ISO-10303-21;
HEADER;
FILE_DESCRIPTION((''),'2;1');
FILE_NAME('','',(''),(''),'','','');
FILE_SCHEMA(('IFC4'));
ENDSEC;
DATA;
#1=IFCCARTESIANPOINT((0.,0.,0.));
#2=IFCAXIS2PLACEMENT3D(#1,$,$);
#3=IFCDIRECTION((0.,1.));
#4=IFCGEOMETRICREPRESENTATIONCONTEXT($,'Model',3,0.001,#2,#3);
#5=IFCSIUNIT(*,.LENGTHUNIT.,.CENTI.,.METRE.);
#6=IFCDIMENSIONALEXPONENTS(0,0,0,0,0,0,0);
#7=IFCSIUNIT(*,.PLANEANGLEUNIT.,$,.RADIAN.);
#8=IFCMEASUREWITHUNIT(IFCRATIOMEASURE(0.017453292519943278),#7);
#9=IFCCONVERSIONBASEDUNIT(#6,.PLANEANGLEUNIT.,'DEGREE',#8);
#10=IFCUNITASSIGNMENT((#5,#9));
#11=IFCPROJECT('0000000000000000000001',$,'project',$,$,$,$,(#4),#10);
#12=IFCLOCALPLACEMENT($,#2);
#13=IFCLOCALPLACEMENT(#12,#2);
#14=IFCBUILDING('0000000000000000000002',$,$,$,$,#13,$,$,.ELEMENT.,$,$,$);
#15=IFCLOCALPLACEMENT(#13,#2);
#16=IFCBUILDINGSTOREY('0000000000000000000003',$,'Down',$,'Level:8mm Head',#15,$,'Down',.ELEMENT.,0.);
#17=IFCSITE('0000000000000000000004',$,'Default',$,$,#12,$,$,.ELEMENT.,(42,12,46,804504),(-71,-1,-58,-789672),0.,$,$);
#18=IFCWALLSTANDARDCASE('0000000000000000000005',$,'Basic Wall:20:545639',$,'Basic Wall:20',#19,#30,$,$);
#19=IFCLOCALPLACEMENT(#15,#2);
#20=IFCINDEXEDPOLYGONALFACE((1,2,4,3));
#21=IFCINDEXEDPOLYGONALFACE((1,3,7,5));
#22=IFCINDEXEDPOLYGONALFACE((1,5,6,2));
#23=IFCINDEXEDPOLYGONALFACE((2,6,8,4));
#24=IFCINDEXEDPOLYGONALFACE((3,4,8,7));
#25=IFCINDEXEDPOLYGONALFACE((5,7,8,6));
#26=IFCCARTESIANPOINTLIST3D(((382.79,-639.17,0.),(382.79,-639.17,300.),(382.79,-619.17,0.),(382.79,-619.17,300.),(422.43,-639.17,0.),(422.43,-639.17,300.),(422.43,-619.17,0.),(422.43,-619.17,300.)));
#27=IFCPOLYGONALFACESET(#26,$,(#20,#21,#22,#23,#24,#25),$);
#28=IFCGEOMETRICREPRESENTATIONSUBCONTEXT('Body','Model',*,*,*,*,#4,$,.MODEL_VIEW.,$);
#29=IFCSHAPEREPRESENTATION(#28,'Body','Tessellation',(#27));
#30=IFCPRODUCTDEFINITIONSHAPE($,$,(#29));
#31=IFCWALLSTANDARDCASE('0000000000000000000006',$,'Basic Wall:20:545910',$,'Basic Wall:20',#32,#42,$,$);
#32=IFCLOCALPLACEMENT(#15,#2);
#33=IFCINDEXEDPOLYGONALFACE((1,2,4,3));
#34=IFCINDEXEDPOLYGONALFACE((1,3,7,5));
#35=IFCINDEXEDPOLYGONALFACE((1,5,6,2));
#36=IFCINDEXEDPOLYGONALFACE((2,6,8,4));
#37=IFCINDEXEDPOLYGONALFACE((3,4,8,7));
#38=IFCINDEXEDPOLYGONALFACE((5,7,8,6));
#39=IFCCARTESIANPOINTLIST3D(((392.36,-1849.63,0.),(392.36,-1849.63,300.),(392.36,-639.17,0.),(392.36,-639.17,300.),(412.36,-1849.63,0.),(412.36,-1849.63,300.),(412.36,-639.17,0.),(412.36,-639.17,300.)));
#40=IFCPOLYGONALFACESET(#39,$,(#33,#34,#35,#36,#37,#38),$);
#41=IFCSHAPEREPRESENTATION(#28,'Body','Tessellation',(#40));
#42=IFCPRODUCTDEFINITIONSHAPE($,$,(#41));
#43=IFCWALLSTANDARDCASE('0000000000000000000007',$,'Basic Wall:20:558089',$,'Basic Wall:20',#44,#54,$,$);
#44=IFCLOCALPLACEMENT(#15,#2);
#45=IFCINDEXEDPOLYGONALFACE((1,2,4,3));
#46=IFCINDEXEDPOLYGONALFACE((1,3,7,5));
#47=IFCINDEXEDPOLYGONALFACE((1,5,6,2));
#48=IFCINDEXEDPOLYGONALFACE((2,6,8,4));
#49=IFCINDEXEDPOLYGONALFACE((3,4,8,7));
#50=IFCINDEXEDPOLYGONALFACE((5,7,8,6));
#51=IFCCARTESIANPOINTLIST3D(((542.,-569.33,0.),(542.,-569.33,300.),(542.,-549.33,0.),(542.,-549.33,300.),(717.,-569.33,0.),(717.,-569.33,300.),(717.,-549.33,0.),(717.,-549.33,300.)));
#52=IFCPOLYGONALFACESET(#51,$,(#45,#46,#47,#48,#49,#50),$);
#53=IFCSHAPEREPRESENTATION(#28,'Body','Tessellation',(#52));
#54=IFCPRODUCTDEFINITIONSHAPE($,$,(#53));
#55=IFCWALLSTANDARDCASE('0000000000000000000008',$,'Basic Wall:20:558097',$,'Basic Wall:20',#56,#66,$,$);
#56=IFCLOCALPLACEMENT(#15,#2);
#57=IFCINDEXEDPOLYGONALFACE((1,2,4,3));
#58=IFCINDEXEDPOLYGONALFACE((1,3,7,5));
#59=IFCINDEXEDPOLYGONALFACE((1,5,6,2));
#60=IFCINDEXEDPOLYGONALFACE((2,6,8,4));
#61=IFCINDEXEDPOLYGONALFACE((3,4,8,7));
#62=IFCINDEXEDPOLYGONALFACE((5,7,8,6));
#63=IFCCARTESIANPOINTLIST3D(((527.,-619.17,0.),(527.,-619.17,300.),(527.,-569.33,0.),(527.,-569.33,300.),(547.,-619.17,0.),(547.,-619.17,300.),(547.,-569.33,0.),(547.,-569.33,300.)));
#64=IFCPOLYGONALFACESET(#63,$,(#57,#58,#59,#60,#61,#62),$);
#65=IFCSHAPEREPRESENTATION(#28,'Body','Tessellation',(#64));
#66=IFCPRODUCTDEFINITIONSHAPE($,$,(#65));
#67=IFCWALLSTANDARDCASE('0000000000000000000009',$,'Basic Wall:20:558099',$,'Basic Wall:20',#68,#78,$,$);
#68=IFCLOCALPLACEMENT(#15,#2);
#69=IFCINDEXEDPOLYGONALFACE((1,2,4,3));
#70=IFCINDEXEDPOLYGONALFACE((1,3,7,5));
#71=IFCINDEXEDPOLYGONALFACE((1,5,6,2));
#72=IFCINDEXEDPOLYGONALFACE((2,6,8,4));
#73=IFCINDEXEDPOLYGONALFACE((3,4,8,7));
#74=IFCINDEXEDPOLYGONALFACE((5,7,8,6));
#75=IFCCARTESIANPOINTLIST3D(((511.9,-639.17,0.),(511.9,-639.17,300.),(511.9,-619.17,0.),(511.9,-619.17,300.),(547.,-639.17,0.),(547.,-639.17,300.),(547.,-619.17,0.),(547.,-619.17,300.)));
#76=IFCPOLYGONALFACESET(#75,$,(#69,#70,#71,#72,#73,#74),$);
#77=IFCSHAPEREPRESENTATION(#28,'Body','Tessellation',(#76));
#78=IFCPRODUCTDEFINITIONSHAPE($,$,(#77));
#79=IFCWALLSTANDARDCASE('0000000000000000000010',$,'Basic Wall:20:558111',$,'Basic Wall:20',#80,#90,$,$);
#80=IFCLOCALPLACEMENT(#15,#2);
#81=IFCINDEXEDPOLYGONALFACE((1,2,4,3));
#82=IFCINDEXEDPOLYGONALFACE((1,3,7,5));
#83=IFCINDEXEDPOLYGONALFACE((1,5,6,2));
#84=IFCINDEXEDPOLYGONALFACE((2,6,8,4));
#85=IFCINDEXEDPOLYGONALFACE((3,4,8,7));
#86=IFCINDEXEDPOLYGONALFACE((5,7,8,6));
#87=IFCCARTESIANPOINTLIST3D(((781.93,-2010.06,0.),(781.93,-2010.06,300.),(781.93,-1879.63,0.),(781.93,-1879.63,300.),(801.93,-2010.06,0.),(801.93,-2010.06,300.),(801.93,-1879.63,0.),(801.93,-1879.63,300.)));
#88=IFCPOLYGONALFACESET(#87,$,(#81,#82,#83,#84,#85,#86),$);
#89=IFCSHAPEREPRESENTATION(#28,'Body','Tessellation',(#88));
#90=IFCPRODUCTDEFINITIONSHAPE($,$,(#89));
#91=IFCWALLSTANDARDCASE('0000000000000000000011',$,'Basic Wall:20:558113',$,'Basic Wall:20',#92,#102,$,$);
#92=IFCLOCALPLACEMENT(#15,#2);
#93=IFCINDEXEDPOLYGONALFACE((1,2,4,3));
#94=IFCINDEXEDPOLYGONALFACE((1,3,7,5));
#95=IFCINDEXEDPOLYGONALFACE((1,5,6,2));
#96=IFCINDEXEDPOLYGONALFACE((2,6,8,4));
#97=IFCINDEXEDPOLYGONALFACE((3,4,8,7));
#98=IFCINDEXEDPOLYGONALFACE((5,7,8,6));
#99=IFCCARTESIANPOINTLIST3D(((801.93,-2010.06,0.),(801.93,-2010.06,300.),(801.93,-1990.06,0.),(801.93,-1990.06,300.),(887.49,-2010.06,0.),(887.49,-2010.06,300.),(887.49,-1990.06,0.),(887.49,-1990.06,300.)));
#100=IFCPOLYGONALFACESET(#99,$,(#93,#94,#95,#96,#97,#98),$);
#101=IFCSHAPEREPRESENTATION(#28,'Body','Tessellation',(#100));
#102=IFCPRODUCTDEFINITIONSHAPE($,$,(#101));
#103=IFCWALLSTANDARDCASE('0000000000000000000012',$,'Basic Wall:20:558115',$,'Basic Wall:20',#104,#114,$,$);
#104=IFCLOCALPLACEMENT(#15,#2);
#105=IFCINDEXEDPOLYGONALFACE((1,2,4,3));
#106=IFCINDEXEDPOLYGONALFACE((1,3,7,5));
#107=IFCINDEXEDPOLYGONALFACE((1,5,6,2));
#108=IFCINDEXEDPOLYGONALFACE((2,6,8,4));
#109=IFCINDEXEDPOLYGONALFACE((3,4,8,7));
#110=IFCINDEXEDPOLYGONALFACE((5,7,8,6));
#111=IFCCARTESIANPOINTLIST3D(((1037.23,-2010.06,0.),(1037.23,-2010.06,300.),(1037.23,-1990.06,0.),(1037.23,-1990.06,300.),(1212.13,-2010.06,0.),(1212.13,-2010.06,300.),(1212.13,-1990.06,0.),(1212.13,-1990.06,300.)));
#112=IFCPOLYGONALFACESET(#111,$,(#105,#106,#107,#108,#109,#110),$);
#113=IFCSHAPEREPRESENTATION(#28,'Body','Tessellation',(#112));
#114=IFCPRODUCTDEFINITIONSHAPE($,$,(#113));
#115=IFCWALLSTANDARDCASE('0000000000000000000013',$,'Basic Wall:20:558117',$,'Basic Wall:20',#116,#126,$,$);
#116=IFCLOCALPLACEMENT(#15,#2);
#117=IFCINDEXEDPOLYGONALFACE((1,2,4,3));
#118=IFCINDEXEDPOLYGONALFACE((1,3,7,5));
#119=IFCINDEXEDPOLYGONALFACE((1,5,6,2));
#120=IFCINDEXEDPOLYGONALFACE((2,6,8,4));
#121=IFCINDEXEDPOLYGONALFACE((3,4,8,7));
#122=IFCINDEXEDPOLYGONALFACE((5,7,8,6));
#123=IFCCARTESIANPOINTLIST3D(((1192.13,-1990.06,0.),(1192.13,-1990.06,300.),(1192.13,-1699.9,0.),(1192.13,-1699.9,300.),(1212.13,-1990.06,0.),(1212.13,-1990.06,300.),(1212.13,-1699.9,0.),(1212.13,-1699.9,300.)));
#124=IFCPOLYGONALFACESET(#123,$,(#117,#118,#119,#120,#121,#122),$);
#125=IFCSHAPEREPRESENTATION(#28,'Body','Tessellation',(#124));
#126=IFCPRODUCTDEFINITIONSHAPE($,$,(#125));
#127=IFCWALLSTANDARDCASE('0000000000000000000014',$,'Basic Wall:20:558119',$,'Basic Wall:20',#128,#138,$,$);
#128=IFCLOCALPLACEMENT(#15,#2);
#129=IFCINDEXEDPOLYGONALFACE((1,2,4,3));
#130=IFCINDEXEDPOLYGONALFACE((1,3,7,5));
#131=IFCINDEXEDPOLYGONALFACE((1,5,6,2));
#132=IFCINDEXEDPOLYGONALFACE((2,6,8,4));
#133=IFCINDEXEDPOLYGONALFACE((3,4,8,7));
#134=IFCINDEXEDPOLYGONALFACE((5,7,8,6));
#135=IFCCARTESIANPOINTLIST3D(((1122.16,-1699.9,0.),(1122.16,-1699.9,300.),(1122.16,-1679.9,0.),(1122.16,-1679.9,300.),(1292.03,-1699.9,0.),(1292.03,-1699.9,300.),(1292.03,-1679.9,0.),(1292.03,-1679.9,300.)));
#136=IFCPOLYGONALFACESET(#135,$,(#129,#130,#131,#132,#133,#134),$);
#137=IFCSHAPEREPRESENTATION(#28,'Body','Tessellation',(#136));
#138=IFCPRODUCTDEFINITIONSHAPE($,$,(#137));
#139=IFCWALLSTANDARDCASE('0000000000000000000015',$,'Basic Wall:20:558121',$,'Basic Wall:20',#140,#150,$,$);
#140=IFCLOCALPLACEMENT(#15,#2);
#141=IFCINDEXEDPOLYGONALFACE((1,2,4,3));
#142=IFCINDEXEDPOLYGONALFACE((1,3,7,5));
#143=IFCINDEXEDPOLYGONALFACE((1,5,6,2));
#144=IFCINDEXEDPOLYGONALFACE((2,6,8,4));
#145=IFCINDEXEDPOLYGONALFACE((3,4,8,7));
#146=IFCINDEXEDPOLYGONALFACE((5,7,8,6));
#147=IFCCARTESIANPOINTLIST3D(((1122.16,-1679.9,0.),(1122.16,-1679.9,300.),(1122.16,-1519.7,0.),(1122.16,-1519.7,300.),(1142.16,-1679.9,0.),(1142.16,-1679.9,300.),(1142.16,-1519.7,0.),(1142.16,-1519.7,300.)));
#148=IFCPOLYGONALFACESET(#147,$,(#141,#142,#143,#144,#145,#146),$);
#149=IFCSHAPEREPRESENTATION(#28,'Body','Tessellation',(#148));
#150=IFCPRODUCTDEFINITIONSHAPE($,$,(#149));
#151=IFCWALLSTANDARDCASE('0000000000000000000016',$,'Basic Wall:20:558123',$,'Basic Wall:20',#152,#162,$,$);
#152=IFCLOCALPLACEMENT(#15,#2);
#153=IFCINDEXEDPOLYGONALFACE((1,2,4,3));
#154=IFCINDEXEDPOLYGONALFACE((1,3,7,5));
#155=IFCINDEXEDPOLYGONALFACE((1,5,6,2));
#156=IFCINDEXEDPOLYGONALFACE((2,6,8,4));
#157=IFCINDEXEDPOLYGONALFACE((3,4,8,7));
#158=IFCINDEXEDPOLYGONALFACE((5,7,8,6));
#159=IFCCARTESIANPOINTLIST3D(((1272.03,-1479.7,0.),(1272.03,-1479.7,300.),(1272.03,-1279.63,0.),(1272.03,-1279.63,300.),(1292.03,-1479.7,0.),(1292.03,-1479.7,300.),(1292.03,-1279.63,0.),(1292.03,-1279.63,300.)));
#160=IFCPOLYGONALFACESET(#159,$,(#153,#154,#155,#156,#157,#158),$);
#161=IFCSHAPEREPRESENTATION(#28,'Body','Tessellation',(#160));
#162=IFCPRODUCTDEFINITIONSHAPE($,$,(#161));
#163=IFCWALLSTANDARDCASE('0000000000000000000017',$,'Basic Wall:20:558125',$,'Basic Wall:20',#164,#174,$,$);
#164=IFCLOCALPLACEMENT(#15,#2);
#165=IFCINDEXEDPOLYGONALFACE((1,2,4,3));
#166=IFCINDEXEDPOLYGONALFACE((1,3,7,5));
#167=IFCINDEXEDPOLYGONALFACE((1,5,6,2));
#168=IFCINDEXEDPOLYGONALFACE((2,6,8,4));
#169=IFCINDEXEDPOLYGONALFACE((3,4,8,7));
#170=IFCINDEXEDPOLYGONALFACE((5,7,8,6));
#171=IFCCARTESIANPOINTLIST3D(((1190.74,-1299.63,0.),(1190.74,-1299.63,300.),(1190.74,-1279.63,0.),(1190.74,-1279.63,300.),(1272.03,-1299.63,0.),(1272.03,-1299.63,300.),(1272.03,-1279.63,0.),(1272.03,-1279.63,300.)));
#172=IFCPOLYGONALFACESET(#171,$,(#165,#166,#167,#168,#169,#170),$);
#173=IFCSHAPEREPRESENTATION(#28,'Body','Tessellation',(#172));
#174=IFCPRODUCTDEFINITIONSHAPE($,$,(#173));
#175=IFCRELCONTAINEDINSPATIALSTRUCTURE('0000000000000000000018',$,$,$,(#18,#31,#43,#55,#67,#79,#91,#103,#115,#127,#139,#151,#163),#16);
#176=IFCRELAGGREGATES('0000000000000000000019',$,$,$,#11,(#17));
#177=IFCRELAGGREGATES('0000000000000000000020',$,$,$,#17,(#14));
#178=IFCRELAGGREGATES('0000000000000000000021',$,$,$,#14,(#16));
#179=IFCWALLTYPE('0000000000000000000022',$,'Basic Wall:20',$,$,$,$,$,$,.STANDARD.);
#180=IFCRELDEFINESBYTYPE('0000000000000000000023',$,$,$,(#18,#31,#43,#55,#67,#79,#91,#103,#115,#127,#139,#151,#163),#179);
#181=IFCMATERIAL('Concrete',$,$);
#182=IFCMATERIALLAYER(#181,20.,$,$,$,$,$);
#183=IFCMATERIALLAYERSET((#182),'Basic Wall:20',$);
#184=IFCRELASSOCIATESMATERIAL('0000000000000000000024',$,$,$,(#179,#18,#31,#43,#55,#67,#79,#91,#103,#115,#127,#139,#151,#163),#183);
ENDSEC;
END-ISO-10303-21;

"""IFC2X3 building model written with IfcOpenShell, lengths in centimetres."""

from ifc_helpers import new_model, entity, si_unit, converted_unit, direction, frame, frame_2d, origin, place, context, subcontext, project, spatial, rectangle, extrude, material, layer, layer_set, layer_usage, type_object, element, save


model = new_model("IFC2X3")

# Units and contexts
model_context = context("Model", 3, precision=0.001, world=origin(), true_north=direction((0.0, 1.0)))
body_context = subcontext(model_context, "Body", "Model", "MODEL_VIEW")
ifc_project = project(units=[si_unit("LENGTHUNIT", "METRE", prefix="CENTI"), converted_unit("PLANEANGLEUNIT", "DEGREE", entity("IfcRatioMeasure", 0.017453292519943278), si_unit("PLANEANGLEUNIT", "RADIAN"), dimensions=[0, 0, 0, 0, 0, 0, 0])], contexts=[model_context])

# Site, building, storey
site_placement = place(None, origin())
site = spatial("IfcSite", under=ifc_project, at=site_placement, Name="Default", CompositionType="ELEMENT", RefLatitude=(42, 12, 46, 804504), RefLongitude=(-71, -1, -58, -789672), RefElevation=0.0)
building_placement = place(site_placement, origin())
building = spatial("IfcBuilding", under=site, at=building_placement, CompositionType="ELEMENT")
storey_placement = place(building_placement, origin())
storey = spatial("IfcBuildingStorey", under=building, at=storey_placement, Name="Down", ObjectType="Level:8mm Head", LongName="Down", CompositionType="ELEMENT", Elevation=0.0)

# Walls
ifc_material = material(Name="Concrete")
ifc_layer_1 = layer(ifc_material, 20.0)
ifc_layer_set_1 = layer_set([ifc_layer_1], Name="Basic Wall:20")
ifc_layer_usage_1 = layer_usage(ifc_layer_set_1, "AXIS2", "POSITIVE", -10.0)
wall_type_1 = type_object("IfcWallType", Name="Basic Wall:20", PredefinedType="STANDARD", material=ifc_layer_set_1)
wall_1_placement = place(storey_placement, frame((382.79, -629.17, 0.0)))
element("IfcWallStandardCase", 1, at=wall_1_placement, inside=storey, type_object=wall_type_1, material=ifc_layer_usage_1, Name="Basic Wall:20:545639", ObjectType="Basic Wall:20", context=body_context, shape_type="SweptSolid", body=[
    extrude(rectangle(XDim=39.64, YDim=20.0, at=frame_2d((19.82, 0.0), x_axis=(-1.0, 0.0))), origin(), (0.0, 0.0, 1.0), 300.0),
])
ifc_layer_usage_2 = layer_usage(ifc_layer_set_1, "AXIS2", "NEGATIVE", 10.0)
wall_2_placement = place(storey_placement, frame((402.36, -639.17, 0.0), z_axis=(0.0, 0.0, 1.0), x_axis=(0.0, -1.0, 0.0)))
element("IfcWallStandardCase", 2, at=wall_2_placement, inside=storey, type_object=wall_type_1, material=ifc_layer_usage_2, Name="Basic Wall:20:545910", ObjectType="Basic Wall:20", context=body_context, shape_type="SweptSolid", body=[
    extrude(rectangle(XDim=1210.46, YDim=20.0, at=frame_2d((605.23, 0.0), x_axis=(-1.0, 0.0))), origin(), (0.0, 0.0, 1.0), 300.0),
])
ifc_layer_usage_3 = layer_usage(ifc_layer_set_1, "AXIS2", "NEGATIVE", 10.0)
wall_3_placement = place(storey_placement, frame((717.0, -559.33, 0.0), z_axis=(0.0, 0.0, 1.0), x_axis=(-1.0, 0.0, 0.0)))
element("IfcWallStandardCase", 3, at=wall_3_placement, inside=storey, type_object=wall_type_1, material=ifc_layer_usage_3, Name="Basic Wall:20:558089", ObjectType="Basic Wall:20", context=body_context, shape_type="SweptSolid", body=[
    extrude(rectangle(XDim=175.0, YDim=20.0, at=frame_2d((87.5, 0.0), x_axis=(-1.0, 0.0))), origin(), (0.0, 0.0, 1.0), 300.0),
])
ifc_layer_usage_4 = layer_usage(ifc_layer_set_1, "AXIS2", "POSITIVE", -10.0)
wall_4_placement = place(storey_placement, frame((537.0, -569.33, 0.0), z_axis=(0.0, 0.0, 1.0), x_axis=(0.0, -1.0, 0.0)))
element("IfcWallStandardCase", 4, at=wall_4_placement, inside=storey, type_object=wall_type_1, material=ifc_layer_usage_4, Name="Basic Wall:20:558097", ObjectType="Basic Wall:20", context=body_context, shape_type="SweptSolid", body=[
    extrude(rectangle(XDim=49.83, YDim=20.0, at=frame_2d((24.92, 0.0), x_axis=(-1.0, 0.0))), origin(), (0.0, 0.0, 1.0), 300.0),
])
ifc_layer_usage_5 = layer_usage(ifc_layer_set_1, "AXIS2", "NEGATIVE", 10.0)
wall_5_placement = place(storey_placement, frame((547.0, -629.17, 0.0), z_axis=(0.0, 0.0, 1.0), x_axis=(-1.0, 0.0, 0.0)))
element("IfcWallStandardCase", 5, at=wall_5_placement, inside=storey, type_object=wall_type_1, material=ifc_layer_usage_5, Name="Basic Wall:20:558099", ObjectType="Basic Wall:20", context=body_context, shape_type="SweptSolid", body=[
    extrude(rectangle(XDim=35.1, YDim=20.0, at=frame_2d((17.55, 0.0), x_axis=(-1.0, 0.0))), origin(), (0.0, 0.0, 1.0), 300.0),
])
ifc_layer_usage_6 = layer_usage(ifc_layer_set_1, "AXIS2", "NEGATIVE", 10.0)
wall_6_placement = place(storey_placement, frame((791.93, -1879.63, 0.0), z_axis=(0.0, 0.0, 1.0), x_axis=(0.0, -1.0, 0.0)))
element("IfcWallStandardCase", 6, at=wall_6_placement, inside=storey, type_object=wall_type_1, material=ifc_layer_usage_6, Name="Basic Wall:20:558111", ObjectType="Basic Wall:20", context=body_context, shape_type="SweptSolid", body=[
    extrude(rectangle(XDim=130.43, YDim=20.0, at=frame_2d((65.22, 0.0), x_axis=(-1.0, 0.0))), origin(), (0.0, 0.0, 1.0), 300.0),
])
ifc_layer_usage_7 = layer_usage(ifc_layer_set_1, "AXIS2", "POSITIVE", -10.0)
wall_7_placement = place(storey_placement, frame((801.93, -2000.06, 0.0)))
element("IfcWallStandardCase", 7, at=wall_7_placement, inside=storey, type_object=wall_type_1, material=ifc_layer_usage_7, Name="Basic Wall:20:558113", ObjectType="Basic Wall:20", context=body_context, shape_type="SweptSolid", body=[
    extrude(rectangle(XDim=85.56, YDim=20.0, at=frame_2d((42.78, 0.0), x_axis=(-1.0, 0.0))), origin(), (0.0, 0.0, 1.0), 300.0),
])
ifc_layer_usage_8 = layer_usage(ifc_layer_set_1, "AXIS2", "POSITIVE", -10.0)
wall_8_placement = place(storey_placement, frame((1037.23, -2000.06, 0.0)))
element("IfcWallStandardCase", 8, at=wall_8_placement, inside=storey, type_object=wall_type_1, material=ifc_layer_usage_8, Name="Basic Wall:20:558115", ObjectType="Basic Wall:20", context=body_context, shape_type="SweptSolid", body=[
    extrude(rectangle(XDim=174.9, YDim=20.0, at=frame_2d((87.45, 0.0), x_axis=(-1.0, 0.0))), origin(), (0.0, 0.0, 1.0), 300.0),
])
ifc_layer_usage_9 = layer_usage(ifc_layer_set_1, "AXIS2", "POSITIVE", -10.0)
wall_9_placement = place(storey_placement, frame((1202.13, -1990.06, 0.0), z_axis=(0.0, 0.0, 1.0), x_axis=(0.0, 1.0, 0.0)))
element("IfcWallStandardCase", 9, at=wall_9_placement, inside=storey, type_object=wall_type_1, material=ifc_layer_usage_9, Name="Basic Wall:20:558117", ObjectType="Basic Wall:20", context=body_context, shape_type="SweptSolid", body=[
    extrude(rectangle(XDim=290.17, YDim=20.0, at=frame_2d((145.08, 0.0), x_axis=(-1.0, 0.0))), origin(), (0.0, 0.0, 1.0), 300.0),
])
ifc_layer_usage_10 = layer_usage(ifc_layer_set_1, "AXIS2", "NEGATIVE", 10.0)
wall_10_placement = place(storey_placement, frame((1292.03, -1689.9, 0.0), z_axis=(0.0, 0.0, 1.0), x_axis=(-1.0, 0.0, 0.0)))
element("IfcWallStandardCase", 10, at=wall_10_placement, inside=storey, type_object=wall_type_1, material=ifc_layer_usage_10, Name="Basic Wall:20:558119", ObjectType="Basic Wall:20", context=body_context, shape_type="SweptSolid", body=[
    extrude(rectangle(XDim=169.87, YDim=20.0, at=frame_2d((84.93, 0.0), x_axis=(-1.0, 0.0))), origin(), (0.0, 0.0, 1.0), 300.0),
])
ifc_layer_usage_11 = layer_usage(ifc_layer_set_1, "AXIS2", "NEGATIVE", 10.0)
wall_11_placement = place(storey_placement, frame((1132.16, -1679.9, 0.0), z_axis=(0.0, 0.0, 1.0), x_axis=(0.0, 1.0, 0.0)))
element("IfcWallStandardCase", 11, at=wall_11_placement, inside=storey, type_object=wall_type_1, material=ifc_layer_usage_11, Name="Basic Wall:20:558121", ObjectType="Basic Wall:20", context=body_context, shape_type="SweptSolid", body=[
    extrude(rectangle(XDim=160.2, YDim=20.0, at=frame_2d((80.1, 0.0), x_axis=(-1.0, 0.0))), origin(), (0.0, 0.0, 1.0), 300.0),
])
ifc_layer_usage_12 = layer_usage(ifc_layer_set_1, "AXIS2", "POSITIVE", -10.0)
wall_12_placement = place(storey_placement, frame((1282.03, -1479.7, 0.0), z_axis=(0.0, 0.0, 1.0), x_axis=(0.0, 1.0, 0.0)))
element("IfcWallStandardCase", 12, at=wall_12_placement, inside=storey, type_object=wall_type_1, material=ifc_layer_usage_12, Name="Basic Wall:20:558123", ObjectType="Basic Wall:20", context=body_context, shape_type="SweptSolid", body=[
    extrude(rectangle(XDim=200.07, YDim=20.0, at=frame_2d((100.03, 0.0), x_axis=(-1.0, 0.0))), origin(), (0.0, 0.0, 1.0), 300.0),
])
ifc_layer_usage_13 = layer_usage(ifc_layer_set_1, "AXIS2", "POSITIVE", -10.0)
wall_13_placement = place(storey_placement, frame((1272.03, -1289.63, 0.0), z_axis=(0.0, 0.0, 1.0), x_axis=(-1.0, 0.0, 0.0)))
element("IfcWallStandardCase", 13, at=wall_13_placement, inside=storey, type_object=wall_type_1, material=ifc_layer_usage_13, Name="Basic Wall:20:558125", ObjectType="Basic Wall:20", context=body_context, shape_type="SweptSolid", body=[
    extrude(rectangle(XDim=81.29, YDim=20.0, at=frame_2d((40.65, 0.0), x_axis=(-1.0, 0.0))), origin(), (0.0, 0.0, 1.0), 300.0),
])

save(model, "model.ifc")
